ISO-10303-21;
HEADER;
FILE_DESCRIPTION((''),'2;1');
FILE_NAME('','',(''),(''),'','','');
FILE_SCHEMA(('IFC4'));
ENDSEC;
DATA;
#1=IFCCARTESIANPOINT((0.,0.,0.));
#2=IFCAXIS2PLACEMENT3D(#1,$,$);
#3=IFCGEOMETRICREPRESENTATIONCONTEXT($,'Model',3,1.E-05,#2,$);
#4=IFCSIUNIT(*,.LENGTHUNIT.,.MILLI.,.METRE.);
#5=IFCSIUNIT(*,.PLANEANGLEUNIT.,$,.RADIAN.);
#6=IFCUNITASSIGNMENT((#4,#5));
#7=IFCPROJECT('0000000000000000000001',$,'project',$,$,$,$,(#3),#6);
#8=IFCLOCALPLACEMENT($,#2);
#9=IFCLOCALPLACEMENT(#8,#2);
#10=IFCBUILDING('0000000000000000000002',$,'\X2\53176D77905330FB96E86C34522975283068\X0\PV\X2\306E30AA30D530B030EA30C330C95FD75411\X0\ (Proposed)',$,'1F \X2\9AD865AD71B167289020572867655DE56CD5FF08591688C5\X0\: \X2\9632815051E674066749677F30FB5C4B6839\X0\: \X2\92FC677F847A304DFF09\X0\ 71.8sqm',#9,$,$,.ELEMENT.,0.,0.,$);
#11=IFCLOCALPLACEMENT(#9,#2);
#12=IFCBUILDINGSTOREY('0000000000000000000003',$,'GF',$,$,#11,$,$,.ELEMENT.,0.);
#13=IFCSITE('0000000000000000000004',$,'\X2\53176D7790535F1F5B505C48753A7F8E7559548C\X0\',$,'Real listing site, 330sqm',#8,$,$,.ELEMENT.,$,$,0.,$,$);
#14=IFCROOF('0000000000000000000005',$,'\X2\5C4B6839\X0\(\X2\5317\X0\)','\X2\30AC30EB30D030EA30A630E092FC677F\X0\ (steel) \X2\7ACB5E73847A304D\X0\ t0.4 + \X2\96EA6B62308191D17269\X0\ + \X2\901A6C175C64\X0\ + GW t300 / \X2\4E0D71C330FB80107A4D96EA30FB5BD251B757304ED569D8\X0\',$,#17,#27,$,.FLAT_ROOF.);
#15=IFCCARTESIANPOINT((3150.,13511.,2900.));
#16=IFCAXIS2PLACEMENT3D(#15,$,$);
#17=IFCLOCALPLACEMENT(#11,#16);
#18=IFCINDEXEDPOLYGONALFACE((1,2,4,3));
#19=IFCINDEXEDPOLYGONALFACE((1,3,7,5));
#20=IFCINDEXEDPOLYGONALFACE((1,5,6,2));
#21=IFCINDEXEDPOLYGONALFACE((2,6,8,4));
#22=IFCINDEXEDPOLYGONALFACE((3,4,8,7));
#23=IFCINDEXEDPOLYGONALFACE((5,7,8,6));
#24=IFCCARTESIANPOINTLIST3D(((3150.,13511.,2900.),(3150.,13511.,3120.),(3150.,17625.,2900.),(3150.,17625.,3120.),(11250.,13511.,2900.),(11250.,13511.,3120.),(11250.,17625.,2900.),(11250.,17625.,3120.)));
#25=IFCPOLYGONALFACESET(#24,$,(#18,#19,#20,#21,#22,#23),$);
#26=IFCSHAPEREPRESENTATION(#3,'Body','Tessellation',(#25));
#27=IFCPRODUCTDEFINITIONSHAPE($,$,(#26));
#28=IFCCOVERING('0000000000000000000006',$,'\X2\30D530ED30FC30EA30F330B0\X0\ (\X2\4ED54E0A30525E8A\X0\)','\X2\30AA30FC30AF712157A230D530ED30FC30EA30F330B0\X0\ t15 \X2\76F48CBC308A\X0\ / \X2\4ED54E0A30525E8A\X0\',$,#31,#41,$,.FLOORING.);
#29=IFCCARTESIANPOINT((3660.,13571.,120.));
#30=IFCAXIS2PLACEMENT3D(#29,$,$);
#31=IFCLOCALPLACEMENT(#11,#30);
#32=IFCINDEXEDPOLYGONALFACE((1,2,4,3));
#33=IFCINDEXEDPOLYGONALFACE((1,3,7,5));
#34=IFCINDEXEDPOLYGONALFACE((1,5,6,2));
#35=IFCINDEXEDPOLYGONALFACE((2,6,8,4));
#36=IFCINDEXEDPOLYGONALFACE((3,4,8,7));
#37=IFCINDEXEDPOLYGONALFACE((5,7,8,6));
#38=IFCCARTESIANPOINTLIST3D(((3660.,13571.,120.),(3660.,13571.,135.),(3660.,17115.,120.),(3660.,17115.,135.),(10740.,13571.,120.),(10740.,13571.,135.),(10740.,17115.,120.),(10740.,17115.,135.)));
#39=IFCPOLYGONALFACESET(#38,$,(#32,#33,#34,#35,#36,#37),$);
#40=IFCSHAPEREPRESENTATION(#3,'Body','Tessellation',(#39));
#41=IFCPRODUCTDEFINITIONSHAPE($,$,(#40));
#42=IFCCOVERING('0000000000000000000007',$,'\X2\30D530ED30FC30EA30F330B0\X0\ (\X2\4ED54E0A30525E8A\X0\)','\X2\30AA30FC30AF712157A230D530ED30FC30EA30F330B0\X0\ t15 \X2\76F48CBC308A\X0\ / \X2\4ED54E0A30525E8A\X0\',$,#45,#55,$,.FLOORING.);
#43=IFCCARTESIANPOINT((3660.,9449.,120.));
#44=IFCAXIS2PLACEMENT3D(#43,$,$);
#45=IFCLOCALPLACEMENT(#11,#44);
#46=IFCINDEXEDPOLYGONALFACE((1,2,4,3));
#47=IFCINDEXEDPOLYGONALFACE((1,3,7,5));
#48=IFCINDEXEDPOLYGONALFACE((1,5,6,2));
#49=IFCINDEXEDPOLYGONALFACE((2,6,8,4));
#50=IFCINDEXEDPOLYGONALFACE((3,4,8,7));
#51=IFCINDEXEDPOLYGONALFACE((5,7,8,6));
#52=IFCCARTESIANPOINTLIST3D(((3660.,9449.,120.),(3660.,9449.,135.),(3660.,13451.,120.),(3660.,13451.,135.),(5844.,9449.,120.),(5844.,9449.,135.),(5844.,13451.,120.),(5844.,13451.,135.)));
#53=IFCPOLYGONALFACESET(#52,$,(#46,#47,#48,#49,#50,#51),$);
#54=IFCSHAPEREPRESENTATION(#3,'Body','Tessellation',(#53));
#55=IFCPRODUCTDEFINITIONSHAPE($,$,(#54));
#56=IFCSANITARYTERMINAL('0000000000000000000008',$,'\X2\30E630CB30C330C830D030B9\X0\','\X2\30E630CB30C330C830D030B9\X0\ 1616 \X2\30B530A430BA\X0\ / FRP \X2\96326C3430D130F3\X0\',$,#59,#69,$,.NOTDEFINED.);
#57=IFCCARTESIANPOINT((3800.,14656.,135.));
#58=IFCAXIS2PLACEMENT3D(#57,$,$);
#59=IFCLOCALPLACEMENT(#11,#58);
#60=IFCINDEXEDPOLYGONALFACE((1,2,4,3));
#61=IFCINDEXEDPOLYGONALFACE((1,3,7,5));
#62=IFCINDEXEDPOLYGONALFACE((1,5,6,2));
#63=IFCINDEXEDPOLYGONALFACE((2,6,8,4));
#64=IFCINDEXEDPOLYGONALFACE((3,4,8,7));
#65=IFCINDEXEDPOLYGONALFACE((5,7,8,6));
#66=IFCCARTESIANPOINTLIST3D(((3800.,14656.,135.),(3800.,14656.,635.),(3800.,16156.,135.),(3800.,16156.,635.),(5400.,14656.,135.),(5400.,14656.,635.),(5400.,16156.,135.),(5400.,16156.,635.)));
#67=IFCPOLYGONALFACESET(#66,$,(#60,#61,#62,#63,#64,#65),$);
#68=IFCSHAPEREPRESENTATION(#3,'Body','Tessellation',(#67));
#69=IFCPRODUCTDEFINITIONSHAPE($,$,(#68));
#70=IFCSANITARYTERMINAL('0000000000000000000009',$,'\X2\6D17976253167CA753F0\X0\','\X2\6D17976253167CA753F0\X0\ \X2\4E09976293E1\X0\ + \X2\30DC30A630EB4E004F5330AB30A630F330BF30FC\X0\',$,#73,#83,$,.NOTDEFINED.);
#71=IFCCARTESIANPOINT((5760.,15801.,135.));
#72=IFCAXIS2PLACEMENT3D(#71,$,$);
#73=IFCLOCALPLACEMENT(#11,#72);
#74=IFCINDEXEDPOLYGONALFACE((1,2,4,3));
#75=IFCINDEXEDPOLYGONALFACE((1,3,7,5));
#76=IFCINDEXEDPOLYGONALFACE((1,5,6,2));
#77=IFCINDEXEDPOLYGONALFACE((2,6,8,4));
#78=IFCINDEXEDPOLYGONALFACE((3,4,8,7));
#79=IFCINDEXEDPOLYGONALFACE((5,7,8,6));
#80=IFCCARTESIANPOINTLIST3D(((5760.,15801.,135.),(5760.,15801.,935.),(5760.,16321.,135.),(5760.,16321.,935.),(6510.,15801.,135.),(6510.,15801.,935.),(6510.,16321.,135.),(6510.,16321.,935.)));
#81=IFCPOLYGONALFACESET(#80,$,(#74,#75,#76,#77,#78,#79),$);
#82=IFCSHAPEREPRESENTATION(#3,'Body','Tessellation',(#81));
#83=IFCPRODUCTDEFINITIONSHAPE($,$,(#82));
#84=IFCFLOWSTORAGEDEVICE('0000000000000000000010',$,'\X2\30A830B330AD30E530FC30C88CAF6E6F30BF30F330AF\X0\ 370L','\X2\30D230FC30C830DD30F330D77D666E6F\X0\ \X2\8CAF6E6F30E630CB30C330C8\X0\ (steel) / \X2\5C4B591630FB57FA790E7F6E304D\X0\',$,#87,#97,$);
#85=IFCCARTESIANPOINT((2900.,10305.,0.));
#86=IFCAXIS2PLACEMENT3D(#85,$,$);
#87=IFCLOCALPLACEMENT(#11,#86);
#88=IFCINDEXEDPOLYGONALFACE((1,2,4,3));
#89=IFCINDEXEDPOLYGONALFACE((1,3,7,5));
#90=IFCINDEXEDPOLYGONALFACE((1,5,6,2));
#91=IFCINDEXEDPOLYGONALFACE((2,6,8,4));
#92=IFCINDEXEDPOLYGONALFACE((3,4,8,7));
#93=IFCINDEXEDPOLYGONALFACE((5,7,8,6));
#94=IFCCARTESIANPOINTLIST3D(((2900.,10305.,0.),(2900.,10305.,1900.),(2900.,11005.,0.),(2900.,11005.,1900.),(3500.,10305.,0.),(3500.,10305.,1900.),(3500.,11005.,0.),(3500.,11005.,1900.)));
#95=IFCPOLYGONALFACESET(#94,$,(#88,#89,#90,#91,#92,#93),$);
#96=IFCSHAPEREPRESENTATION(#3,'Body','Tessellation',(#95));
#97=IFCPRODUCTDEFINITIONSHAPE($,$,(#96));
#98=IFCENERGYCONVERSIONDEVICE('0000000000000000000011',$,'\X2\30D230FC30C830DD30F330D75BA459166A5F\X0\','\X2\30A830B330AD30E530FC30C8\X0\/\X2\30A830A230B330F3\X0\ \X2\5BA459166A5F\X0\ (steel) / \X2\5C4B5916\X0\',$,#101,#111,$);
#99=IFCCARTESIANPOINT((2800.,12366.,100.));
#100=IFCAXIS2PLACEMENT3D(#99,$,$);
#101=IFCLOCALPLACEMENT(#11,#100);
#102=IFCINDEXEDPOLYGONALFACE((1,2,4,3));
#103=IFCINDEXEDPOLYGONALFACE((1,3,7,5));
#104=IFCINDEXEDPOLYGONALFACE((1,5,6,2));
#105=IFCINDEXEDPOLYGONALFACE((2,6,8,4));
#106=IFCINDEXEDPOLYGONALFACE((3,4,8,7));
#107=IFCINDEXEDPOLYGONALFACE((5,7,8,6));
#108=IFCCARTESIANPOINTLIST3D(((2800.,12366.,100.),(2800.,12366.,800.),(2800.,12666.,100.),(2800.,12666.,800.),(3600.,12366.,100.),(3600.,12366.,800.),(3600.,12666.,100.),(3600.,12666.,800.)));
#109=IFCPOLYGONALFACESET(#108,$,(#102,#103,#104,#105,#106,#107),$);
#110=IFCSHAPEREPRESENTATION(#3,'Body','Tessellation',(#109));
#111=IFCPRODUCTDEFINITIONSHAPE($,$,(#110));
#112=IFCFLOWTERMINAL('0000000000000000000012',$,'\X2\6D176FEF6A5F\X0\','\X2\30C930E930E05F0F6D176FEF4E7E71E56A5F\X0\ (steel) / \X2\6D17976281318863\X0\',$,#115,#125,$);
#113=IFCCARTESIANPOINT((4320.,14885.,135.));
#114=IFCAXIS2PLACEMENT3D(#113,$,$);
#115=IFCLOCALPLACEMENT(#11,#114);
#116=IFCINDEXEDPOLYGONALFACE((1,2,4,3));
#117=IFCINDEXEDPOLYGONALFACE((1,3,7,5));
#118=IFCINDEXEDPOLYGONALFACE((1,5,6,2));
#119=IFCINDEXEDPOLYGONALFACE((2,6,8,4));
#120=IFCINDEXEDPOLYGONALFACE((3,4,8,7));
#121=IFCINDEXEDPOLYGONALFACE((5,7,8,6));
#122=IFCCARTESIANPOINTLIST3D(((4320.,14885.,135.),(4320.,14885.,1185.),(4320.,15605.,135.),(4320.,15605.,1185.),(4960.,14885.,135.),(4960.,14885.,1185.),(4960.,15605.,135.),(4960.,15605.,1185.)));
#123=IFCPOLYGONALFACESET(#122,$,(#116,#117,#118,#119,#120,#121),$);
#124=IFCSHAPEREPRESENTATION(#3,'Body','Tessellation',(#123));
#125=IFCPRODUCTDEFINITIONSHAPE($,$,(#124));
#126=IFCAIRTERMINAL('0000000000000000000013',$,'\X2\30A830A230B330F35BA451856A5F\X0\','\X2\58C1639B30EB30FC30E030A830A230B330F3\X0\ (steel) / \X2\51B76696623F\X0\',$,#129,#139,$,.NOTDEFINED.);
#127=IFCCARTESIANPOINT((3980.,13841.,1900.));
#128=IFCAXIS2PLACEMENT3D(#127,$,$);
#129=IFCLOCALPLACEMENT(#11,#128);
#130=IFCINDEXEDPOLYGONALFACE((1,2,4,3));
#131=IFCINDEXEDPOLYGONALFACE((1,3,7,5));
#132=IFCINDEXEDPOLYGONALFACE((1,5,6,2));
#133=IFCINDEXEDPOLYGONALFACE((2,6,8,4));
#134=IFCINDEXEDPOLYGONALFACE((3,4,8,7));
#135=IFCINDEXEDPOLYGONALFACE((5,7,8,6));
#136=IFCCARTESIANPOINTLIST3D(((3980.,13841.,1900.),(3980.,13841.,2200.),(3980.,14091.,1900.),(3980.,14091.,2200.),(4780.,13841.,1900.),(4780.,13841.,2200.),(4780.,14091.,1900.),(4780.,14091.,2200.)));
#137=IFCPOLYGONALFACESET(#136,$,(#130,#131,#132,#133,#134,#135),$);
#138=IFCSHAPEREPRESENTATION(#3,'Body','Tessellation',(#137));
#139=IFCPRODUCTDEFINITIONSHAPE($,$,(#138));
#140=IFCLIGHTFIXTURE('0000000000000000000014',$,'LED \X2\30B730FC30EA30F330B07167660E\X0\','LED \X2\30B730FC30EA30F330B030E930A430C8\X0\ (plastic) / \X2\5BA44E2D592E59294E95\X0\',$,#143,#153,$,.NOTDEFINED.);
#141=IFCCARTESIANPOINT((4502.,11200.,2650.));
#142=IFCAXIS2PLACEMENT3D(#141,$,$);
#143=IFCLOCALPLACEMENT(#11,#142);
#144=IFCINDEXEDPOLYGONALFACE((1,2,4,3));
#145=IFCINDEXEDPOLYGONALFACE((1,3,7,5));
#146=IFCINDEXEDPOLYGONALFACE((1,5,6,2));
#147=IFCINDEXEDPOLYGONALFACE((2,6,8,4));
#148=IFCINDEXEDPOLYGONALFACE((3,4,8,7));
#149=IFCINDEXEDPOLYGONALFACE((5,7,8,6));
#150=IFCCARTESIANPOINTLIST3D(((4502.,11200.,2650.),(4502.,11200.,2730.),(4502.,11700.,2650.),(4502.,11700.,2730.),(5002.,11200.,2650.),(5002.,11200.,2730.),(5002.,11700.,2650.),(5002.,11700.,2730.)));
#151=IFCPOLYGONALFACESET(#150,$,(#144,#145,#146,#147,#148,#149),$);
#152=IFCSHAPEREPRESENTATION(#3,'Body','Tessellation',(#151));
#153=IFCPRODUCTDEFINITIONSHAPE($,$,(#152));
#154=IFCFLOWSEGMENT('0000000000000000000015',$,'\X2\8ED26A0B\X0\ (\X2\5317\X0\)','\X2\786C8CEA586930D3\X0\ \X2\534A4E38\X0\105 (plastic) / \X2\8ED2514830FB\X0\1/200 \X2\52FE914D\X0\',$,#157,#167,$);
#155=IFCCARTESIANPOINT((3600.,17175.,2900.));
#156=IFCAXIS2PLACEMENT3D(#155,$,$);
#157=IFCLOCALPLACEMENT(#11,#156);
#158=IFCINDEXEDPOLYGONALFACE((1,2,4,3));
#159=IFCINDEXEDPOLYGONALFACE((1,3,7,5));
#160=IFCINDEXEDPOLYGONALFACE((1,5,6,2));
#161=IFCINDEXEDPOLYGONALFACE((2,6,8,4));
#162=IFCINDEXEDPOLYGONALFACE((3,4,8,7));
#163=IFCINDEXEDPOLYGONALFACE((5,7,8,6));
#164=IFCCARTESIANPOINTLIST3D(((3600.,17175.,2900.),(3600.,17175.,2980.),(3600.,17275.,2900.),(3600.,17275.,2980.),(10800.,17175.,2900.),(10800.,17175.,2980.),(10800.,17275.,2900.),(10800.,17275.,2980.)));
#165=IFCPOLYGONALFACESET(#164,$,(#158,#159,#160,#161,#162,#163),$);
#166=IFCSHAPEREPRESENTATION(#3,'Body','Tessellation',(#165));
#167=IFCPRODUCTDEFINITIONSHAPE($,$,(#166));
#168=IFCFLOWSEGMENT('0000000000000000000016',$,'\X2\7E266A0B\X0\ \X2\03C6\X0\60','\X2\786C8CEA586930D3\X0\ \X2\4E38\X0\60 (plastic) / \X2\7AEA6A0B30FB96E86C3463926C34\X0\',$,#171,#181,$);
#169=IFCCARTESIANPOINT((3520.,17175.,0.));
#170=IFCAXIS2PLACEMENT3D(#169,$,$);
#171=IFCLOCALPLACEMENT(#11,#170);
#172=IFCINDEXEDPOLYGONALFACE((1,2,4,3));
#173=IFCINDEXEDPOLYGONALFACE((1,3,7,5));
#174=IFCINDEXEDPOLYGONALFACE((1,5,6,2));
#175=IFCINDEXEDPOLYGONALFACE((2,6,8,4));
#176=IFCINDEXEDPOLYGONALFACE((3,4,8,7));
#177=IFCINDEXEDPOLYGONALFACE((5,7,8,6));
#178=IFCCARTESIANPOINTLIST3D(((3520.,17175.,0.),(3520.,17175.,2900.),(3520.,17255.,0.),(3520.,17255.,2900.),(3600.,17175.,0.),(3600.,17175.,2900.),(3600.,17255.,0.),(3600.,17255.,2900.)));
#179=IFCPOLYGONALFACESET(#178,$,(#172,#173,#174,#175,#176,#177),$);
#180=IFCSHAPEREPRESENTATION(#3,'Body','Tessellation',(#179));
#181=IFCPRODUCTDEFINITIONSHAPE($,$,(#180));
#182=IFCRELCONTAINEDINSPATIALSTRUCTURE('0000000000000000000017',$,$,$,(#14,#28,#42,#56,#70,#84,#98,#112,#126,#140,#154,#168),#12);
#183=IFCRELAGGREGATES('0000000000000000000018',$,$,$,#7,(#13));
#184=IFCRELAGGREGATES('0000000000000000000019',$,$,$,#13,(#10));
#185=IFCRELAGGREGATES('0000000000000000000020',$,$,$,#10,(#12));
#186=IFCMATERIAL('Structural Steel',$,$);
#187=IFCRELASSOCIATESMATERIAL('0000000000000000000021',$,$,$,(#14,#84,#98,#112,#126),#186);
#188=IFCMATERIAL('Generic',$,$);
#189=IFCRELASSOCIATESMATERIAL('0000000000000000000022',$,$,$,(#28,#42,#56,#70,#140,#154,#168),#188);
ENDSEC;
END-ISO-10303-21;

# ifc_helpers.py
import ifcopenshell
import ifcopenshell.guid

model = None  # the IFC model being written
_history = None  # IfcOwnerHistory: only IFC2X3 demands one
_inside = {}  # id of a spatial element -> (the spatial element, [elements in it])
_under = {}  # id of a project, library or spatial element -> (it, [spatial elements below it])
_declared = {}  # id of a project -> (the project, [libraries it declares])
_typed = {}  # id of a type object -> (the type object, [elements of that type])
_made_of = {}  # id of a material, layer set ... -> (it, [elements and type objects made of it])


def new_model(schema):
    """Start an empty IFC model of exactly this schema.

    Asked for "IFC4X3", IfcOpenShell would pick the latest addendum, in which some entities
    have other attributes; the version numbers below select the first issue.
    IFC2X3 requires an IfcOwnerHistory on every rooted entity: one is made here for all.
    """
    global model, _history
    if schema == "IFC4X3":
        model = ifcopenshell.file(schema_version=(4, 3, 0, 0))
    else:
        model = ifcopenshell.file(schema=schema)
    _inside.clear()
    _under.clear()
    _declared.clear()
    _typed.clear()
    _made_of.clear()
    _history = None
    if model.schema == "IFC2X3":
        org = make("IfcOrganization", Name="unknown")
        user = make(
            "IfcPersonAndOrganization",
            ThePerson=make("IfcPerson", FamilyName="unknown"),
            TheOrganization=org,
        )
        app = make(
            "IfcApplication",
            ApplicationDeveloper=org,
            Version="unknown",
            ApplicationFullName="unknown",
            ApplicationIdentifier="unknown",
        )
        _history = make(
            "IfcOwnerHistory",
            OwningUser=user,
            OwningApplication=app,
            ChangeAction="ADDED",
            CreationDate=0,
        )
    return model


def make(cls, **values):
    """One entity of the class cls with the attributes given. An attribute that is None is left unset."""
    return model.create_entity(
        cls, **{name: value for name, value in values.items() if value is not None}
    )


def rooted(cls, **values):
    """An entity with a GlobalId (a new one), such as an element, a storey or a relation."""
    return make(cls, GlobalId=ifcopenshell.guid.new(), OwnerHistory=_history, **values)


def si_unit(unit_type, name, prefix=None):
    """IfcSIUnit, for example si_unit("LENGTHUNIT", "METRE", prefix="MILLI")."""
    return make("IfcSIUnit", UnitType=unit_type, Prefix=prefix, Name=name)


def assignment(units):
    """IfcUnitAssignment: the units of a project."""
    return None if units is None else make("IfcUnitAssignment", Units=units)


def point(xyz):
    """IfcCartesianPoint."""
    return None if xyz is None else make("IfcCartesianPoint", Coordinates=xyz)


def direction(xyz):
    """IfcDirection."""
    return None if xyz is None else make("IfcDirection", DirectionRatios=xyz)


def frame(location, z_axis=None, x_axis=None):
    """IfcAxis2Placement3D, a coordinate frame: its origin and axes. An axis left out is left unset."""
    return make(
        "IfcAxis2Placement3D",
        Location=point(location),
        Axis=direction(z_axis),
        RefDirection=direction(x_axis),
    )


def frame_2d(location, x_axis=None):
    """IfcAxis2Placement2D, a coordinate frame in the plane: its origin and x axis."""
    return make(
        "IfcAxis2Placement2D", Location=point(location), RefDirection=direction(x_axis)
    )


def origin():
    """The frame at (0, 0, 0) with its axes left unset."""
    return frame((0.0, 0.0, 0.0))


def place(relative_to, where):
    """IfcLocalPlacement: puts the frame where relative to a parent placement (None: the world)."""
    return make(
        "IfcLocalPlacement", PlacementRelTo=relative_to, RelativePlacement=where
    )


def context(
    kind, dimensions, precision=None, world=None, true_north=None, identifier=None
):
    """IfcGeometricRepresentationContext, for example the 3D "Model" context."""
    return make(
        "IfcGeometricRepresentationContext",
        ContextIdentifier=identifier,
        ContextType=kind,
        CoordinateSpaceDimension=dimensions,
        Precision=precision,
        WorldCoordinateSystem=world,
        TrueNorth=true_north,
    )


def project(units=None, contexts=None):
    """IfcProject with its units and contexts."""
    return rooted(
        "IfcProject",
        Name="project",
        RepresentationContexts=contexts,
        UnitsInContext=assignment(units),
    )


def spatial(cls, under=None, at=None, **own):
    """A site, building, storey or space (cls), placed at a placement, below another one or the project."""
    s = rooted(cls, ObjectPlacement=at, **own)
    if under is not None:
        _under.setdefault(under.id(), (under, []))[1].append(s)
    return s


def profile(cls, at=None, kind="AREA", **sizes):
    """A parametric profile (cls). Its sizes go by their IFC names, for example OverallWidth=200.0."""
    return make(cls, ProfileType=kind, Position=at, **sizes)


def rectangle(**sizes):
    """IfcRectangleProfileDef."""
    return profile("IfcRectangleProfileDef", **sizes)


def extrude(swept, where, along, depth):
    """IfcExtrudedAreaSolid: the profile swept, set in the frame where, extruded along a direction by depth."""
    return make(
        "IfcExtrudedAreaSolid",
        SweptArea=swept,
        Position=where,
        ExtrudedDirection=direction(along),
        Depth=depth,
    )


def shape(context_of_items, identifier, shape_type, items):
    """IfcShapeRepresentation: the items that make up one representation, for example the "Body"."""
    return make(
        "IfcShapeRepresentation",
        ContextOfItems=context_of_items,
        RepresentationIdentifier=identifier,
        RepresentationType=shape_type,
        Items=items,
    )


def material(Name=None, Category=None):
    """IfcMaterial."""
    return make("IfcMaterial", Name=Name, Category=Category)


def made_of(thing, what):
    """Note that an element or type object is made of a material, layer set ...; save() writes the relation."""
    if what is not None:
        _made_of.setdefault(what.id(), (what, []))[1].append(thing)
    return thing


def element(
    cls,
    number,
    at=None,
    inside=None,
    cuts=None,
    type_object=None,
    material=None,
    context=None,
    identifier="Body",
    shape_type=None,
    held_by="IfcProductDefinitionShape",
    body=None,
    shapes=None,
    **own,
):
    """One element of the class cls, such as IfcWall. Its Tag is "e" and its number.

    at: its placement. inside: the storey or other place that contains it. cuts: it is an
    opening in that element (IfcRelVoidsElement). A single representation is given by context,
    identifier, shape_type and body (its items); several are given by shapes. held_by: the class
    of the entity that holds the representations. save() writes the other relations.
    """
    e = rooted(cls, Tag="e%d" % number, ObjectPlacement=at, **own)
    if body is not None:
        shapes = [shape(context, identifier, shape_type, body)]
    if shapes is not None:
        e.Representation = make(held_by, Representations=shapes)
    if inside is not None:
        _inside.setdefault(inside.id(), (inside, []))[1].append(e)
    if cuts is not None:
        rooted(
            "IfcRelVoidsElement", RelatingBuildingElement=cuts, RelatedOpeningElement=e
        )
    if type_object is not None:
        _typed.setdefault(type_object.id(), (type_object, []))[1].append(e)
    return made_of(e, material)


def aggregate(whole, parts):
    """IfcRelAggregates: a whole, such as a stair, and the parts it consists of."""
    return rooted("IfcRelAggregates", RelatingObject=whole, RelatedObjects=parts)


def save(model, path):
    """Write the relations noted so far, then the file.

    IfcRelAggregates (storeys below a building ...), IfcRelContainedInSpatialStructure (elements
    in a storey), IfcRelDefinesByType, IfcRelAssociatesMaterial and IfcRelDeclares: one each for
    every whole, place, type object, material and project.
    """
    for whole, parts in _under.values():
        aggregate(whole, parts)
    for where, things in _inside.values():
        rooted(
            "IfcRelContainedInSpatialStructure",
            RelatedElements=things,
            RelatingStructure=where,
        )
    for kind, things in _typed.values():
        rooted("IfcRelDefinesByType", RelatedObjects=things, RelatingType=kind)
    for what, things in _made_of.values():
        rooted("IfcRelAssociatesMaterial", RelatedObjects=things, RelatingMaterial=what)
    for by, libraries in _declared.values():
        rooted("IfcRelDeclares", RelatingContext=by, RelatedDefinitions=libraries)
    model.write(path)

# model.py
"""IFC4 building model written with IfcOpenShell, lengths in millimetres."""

from ifc_helpers import new_model, si_unit, frame, frame_2d, origin, place, context, project, spatial, rectangle, extrude, material, element, save


model = new_model("IFC4")

# Units and contexts
model_context = context("Model", 3, precision=1e-05, world=origin())
ifc_project = project(units=[si_unit("LENGTHUNIT", "METRE", prefix="MILLI"), si_unit("PLANEANGLEUNIT", "RADIAN")], contexts=[model_context])

# Site, building, storey
site_placement = place(None, origin())
site = spatial("IfcSite", under=ifc_project, at=site_placement, Name="北海道弟子屈町美留和", ObjectType="Real listing site, 330sqm", CompositionType="ELEMENT", RefElevation=0.0)
building_placement = place(site_placement, origin())
building = spatial("IfcBuilding", under=site, at=building_placement, Name="北海道・雨水利用とPVのオフグリッド志向 (Proposed)", ObjectType="1F 高断熱木造在来工法（外装: 防腐処理杉板・屋根: 鋼板葺き） 71.8sqm", CompositionType="ELEMENT", ElevationOfRefHeight=0.0, ElevationOfTerrain=0.0)
storey_placement = place(building_placement, origin())
storey = spatial("IfcBuildingStorey", under=building, at=storey_placement, Name="GF", CompositionType="ELEMENT", Elevation=0.0)

# Roof
ifc_material_1 = material(Name="Structural Steel")
roof_placement = place(storey_placement, frame((3150.0, 13511.0, 2900.0)))
element("IfcRoof", 1, at=roof_placement, inside=storey, material=ifc_material_1, Name="屋根(北)", Description="ガルバリウム鋼板 (steel) 立平葺き t0.4 + 雪止め金物 + 通気層 + GW t300 / 不燃・耐積雪・寒冷地仕様", PredefinedType="FLAT_ROOF", context=model_context, shape_type="SweptSolid", body=[
    extrude(rectangle(XDim=8100.0, YDim=4114.0, at=frame_2d((4050.0, 2057.0))), frame((3150.0, 13511.0, 2900.0)), (0.0, 0.0, 1.0), 220.0),
])

# Coverings
ifc_material_2 = material(Name="Generic")
covering_1_placement = place(storey_placement, frame((3660.0, 13571.0, 120.0)))
element("IfcCovering", 2, at=covering_1_placement, inside=storey, material=ifc_material_2, Name="フローリング (仕上げ床)", Description="オーク無垢フローリング t15 直貼り / 仕上げ床", PredefinedType="FLOORING", context=model_context, shape_type="SweptSolid", body=[
    extrude(rectangle(XDim=7080.0, YDim=3544.0, at=frame_2d((3540.0, 1772.0))), frame((3660.0, 13571.0, 120.0)), (0.0, 0.0, 1.0), 15.0),
])
covering_2_placement = place(storey_placement, frame((3660.0, 9449.0, 120.0)))
element("IfcCovering", 3, at=covering_2_placement, inside=storey, material=ifc_material_2, Name="フローリング (仕上げ床)", Description="オーク無垢フローリング t15 直貼り / 仕上げ床", PredefinedType="FLOORING", context=model_context, shape_type="SweptSolid", body=[
    extrude(rectangle(XDim=2184.0, YDim=4002.0, at=frame_2d((1092.0, 2001.0))), frame((3660.0, 9449.0, 120.0)), (0.0, 0.0, 1.0), 15.0),
])

# Sanitary terminals
sanitary_terminal_1_placement = place(storey_placement, frame((3800.0, 14656.0, 135.0)))
element("IfcSanitaryTerminal", 4, at=sanitary_terminal_1_placement, inside=storey, material=ifc_material_2, Name="ユニットバス", Description="ユニットバス 1616 サイズ / FRP 防水パン", PredefinedType="NOTDEFINED", context=model_context, shape_type="SweptSolid", body=[
    extrude(rectangle(XDim=1600.0, YDim=1500.0, at=frame_2d((800.0, 750.0))), frame((3800.0, 14656.0, 135.0)), (0.0, 0.0, 1.0), 500.0),
])
sanitary_terminal_2_placement = place(storey_placement, frame((5760.0, 15801.0, 135.0)))
element("IfcSanitaryTerminal", 5, at=sanitary_terminal_2_placement, inside=storey, material=ifc_material_2, Name="洗面化粧台", Description="洗面化粧台 三面鏡 + ボウル一体カウンター", PredefinedType="NOTDEFINED", context=model_context, shape_type="SweptSolid", body=[
    extrude(rectangle(XDim=750.0, YDim=520.0, at=frame_2d((375.0, 260.0))), frame((5760.0, 15801.0, 135.0)), (0.0, 0.0, 1.0), 800.0),
])

# Flow storage device
flow_storage_device_placement = place(storey_placement, frame((2900.0, 10305.0, 0.0)))
element("IfcFlowStorageDevice", 6, at=flow_storage_device_placement, inside=storey, material=ifc_material_1, Name="エコキュート貯湯タンク 370L", Description="ヒートポンプ給湯 貯湯ユニット (steel) / 屋外・基礎置き", context=model_context, shape_type="SweptSolid", body=[
    extrude(rectangle(XDim=600.0, YDim=700.0, at=frame_2d((300.0, 350.0))), frame((2900.0, 10305.0, 0.0)), (0.0, 0.0, 1.0), 1900.0),
])

# Energy conversion device
energy_conversion_device_placement = place(storey_placement, frame((2800.0, 12366.0, 100.0)))
element("IfcEnergyConversionDevice", 7, at=energy_conversion_device_placement, inside=storey, material=ifc_material_1, Name="ヒートポンプ室外機", Description="エコキュート/エアコン 室外機 (steel) / 屋外", context=model_context, shape_type="SweptSolid", body=[
    extrude(rectangle(XDim=800.0, YDim=300.0, at=frame_2d((400.0, 150.0))), frame((2800.0, 12366.0, 100.0)), (0.0, 0.0, 1.0), 700.0),
])

# Flow terminal
flow_terminal_placement = place(storey_placement, frame((4320.0, 14885.0, 135.0)))
element("IfcFlowTerminal", 8, at=flow_terminal_placement, inside=storey, material=ifc_material_1, Name="洗濯機", Description="ドラム式洗濯乾燥機 (steel) / 洗面脱衣", context=model_context, shape_type="SweptSolid", body=[
    extrude(rectangle(XDim=640.0, YDim=720.0, at=frame_2d((320.0, 360.0))), frame((4320.0, 14885.0, 135.0)), (0.0, 0.0, 1.0), 1050.0),
])

# Air terminal
air_terminal_placement = place(storey_placement, frame((3980.0, 13841.0, 1900.0)))
element("IfcAirTerminal", 9, at=air_terminal_placement, inside=storey, material=ifc_material_1, Name="エアコン室内機", Description="壁掛ルームエアコン (steel) / 冷暖房", PredefinedType="NOTDEFINED", context=model_context, shape_type="SweptSolid", body=[
    extrude(rectangle(XDim=800.0, YDim=250.0, at=frame_2d((400.0, 125.0))), frame((3980.0, 13841.0, 1900.0)), (0.0, 0.0, 1.0), 300.0),
])

# Light fixture
light_fixture_placement = place(storey_placement, frame((4502.0, 11200.0, 2650.0)))
element("IfcLightFixture", 10, at=light_fixture_placement, inside=storey, material=ifc_material_2, Name="LED シーリング照明", Description="LED シーリングライト (plastic) / 室中央天井", PredefinedType="NOTDEFINED", context=model_context, shape_type="SweptSolid", body=[
    extrude(rectangle(XDim=500.0, YDim=500.0, at=frame_2d((250.0, 250.0))), frame((4502.0, 11200.0, 2650.0)), (0.0, 0.0, 1.0), 80.0),
])

# Flow segments
flow_segment_1_placement = place(storey_placement, frame((3600.0, 17175.0, 2900.0)))
element("IfcFlowSegment", 11, at=flow_segment_1_placement, inside=storey, material=ifc_material_2, Name="軒樋 (北)", Description="硬質塩ビ 半丸105 (plastic) / 軒先・1/200 勾配", context=model_context, shape_type="SweptSolid", body=[
    extrude(rectangle(XDim=7200.0, YDim=100.0, at=frame_2d((3600.0, 50.0))), frame((3600.0, 17175.0, 2900.0)), (0.0, 0.0, 1.0), 80.0),
])
flow_segment_2_placement = place(storey_placement, frame((3520.0, 17175.0, 0.0)))
element("IfcFlowSegment", 12, at=flow_segment_2_placement, inside=storey, material=ifc_material_2, Name="縦樋 φ60", Description="硬質塩ビ 丸60 (plastic) / 竪樋・雨水排水", context=model_context, shape_type="SweptSolid", body=[
    extrude(rectangle(XDim=80.0, YDim=80.0, at=frame_2d((40.0, 40.0))), frame((3520.0, 17175.0, 0.0)), (0.0, 0.0, 1.0), 2900.0),
])

save(model, "model.ifc")
